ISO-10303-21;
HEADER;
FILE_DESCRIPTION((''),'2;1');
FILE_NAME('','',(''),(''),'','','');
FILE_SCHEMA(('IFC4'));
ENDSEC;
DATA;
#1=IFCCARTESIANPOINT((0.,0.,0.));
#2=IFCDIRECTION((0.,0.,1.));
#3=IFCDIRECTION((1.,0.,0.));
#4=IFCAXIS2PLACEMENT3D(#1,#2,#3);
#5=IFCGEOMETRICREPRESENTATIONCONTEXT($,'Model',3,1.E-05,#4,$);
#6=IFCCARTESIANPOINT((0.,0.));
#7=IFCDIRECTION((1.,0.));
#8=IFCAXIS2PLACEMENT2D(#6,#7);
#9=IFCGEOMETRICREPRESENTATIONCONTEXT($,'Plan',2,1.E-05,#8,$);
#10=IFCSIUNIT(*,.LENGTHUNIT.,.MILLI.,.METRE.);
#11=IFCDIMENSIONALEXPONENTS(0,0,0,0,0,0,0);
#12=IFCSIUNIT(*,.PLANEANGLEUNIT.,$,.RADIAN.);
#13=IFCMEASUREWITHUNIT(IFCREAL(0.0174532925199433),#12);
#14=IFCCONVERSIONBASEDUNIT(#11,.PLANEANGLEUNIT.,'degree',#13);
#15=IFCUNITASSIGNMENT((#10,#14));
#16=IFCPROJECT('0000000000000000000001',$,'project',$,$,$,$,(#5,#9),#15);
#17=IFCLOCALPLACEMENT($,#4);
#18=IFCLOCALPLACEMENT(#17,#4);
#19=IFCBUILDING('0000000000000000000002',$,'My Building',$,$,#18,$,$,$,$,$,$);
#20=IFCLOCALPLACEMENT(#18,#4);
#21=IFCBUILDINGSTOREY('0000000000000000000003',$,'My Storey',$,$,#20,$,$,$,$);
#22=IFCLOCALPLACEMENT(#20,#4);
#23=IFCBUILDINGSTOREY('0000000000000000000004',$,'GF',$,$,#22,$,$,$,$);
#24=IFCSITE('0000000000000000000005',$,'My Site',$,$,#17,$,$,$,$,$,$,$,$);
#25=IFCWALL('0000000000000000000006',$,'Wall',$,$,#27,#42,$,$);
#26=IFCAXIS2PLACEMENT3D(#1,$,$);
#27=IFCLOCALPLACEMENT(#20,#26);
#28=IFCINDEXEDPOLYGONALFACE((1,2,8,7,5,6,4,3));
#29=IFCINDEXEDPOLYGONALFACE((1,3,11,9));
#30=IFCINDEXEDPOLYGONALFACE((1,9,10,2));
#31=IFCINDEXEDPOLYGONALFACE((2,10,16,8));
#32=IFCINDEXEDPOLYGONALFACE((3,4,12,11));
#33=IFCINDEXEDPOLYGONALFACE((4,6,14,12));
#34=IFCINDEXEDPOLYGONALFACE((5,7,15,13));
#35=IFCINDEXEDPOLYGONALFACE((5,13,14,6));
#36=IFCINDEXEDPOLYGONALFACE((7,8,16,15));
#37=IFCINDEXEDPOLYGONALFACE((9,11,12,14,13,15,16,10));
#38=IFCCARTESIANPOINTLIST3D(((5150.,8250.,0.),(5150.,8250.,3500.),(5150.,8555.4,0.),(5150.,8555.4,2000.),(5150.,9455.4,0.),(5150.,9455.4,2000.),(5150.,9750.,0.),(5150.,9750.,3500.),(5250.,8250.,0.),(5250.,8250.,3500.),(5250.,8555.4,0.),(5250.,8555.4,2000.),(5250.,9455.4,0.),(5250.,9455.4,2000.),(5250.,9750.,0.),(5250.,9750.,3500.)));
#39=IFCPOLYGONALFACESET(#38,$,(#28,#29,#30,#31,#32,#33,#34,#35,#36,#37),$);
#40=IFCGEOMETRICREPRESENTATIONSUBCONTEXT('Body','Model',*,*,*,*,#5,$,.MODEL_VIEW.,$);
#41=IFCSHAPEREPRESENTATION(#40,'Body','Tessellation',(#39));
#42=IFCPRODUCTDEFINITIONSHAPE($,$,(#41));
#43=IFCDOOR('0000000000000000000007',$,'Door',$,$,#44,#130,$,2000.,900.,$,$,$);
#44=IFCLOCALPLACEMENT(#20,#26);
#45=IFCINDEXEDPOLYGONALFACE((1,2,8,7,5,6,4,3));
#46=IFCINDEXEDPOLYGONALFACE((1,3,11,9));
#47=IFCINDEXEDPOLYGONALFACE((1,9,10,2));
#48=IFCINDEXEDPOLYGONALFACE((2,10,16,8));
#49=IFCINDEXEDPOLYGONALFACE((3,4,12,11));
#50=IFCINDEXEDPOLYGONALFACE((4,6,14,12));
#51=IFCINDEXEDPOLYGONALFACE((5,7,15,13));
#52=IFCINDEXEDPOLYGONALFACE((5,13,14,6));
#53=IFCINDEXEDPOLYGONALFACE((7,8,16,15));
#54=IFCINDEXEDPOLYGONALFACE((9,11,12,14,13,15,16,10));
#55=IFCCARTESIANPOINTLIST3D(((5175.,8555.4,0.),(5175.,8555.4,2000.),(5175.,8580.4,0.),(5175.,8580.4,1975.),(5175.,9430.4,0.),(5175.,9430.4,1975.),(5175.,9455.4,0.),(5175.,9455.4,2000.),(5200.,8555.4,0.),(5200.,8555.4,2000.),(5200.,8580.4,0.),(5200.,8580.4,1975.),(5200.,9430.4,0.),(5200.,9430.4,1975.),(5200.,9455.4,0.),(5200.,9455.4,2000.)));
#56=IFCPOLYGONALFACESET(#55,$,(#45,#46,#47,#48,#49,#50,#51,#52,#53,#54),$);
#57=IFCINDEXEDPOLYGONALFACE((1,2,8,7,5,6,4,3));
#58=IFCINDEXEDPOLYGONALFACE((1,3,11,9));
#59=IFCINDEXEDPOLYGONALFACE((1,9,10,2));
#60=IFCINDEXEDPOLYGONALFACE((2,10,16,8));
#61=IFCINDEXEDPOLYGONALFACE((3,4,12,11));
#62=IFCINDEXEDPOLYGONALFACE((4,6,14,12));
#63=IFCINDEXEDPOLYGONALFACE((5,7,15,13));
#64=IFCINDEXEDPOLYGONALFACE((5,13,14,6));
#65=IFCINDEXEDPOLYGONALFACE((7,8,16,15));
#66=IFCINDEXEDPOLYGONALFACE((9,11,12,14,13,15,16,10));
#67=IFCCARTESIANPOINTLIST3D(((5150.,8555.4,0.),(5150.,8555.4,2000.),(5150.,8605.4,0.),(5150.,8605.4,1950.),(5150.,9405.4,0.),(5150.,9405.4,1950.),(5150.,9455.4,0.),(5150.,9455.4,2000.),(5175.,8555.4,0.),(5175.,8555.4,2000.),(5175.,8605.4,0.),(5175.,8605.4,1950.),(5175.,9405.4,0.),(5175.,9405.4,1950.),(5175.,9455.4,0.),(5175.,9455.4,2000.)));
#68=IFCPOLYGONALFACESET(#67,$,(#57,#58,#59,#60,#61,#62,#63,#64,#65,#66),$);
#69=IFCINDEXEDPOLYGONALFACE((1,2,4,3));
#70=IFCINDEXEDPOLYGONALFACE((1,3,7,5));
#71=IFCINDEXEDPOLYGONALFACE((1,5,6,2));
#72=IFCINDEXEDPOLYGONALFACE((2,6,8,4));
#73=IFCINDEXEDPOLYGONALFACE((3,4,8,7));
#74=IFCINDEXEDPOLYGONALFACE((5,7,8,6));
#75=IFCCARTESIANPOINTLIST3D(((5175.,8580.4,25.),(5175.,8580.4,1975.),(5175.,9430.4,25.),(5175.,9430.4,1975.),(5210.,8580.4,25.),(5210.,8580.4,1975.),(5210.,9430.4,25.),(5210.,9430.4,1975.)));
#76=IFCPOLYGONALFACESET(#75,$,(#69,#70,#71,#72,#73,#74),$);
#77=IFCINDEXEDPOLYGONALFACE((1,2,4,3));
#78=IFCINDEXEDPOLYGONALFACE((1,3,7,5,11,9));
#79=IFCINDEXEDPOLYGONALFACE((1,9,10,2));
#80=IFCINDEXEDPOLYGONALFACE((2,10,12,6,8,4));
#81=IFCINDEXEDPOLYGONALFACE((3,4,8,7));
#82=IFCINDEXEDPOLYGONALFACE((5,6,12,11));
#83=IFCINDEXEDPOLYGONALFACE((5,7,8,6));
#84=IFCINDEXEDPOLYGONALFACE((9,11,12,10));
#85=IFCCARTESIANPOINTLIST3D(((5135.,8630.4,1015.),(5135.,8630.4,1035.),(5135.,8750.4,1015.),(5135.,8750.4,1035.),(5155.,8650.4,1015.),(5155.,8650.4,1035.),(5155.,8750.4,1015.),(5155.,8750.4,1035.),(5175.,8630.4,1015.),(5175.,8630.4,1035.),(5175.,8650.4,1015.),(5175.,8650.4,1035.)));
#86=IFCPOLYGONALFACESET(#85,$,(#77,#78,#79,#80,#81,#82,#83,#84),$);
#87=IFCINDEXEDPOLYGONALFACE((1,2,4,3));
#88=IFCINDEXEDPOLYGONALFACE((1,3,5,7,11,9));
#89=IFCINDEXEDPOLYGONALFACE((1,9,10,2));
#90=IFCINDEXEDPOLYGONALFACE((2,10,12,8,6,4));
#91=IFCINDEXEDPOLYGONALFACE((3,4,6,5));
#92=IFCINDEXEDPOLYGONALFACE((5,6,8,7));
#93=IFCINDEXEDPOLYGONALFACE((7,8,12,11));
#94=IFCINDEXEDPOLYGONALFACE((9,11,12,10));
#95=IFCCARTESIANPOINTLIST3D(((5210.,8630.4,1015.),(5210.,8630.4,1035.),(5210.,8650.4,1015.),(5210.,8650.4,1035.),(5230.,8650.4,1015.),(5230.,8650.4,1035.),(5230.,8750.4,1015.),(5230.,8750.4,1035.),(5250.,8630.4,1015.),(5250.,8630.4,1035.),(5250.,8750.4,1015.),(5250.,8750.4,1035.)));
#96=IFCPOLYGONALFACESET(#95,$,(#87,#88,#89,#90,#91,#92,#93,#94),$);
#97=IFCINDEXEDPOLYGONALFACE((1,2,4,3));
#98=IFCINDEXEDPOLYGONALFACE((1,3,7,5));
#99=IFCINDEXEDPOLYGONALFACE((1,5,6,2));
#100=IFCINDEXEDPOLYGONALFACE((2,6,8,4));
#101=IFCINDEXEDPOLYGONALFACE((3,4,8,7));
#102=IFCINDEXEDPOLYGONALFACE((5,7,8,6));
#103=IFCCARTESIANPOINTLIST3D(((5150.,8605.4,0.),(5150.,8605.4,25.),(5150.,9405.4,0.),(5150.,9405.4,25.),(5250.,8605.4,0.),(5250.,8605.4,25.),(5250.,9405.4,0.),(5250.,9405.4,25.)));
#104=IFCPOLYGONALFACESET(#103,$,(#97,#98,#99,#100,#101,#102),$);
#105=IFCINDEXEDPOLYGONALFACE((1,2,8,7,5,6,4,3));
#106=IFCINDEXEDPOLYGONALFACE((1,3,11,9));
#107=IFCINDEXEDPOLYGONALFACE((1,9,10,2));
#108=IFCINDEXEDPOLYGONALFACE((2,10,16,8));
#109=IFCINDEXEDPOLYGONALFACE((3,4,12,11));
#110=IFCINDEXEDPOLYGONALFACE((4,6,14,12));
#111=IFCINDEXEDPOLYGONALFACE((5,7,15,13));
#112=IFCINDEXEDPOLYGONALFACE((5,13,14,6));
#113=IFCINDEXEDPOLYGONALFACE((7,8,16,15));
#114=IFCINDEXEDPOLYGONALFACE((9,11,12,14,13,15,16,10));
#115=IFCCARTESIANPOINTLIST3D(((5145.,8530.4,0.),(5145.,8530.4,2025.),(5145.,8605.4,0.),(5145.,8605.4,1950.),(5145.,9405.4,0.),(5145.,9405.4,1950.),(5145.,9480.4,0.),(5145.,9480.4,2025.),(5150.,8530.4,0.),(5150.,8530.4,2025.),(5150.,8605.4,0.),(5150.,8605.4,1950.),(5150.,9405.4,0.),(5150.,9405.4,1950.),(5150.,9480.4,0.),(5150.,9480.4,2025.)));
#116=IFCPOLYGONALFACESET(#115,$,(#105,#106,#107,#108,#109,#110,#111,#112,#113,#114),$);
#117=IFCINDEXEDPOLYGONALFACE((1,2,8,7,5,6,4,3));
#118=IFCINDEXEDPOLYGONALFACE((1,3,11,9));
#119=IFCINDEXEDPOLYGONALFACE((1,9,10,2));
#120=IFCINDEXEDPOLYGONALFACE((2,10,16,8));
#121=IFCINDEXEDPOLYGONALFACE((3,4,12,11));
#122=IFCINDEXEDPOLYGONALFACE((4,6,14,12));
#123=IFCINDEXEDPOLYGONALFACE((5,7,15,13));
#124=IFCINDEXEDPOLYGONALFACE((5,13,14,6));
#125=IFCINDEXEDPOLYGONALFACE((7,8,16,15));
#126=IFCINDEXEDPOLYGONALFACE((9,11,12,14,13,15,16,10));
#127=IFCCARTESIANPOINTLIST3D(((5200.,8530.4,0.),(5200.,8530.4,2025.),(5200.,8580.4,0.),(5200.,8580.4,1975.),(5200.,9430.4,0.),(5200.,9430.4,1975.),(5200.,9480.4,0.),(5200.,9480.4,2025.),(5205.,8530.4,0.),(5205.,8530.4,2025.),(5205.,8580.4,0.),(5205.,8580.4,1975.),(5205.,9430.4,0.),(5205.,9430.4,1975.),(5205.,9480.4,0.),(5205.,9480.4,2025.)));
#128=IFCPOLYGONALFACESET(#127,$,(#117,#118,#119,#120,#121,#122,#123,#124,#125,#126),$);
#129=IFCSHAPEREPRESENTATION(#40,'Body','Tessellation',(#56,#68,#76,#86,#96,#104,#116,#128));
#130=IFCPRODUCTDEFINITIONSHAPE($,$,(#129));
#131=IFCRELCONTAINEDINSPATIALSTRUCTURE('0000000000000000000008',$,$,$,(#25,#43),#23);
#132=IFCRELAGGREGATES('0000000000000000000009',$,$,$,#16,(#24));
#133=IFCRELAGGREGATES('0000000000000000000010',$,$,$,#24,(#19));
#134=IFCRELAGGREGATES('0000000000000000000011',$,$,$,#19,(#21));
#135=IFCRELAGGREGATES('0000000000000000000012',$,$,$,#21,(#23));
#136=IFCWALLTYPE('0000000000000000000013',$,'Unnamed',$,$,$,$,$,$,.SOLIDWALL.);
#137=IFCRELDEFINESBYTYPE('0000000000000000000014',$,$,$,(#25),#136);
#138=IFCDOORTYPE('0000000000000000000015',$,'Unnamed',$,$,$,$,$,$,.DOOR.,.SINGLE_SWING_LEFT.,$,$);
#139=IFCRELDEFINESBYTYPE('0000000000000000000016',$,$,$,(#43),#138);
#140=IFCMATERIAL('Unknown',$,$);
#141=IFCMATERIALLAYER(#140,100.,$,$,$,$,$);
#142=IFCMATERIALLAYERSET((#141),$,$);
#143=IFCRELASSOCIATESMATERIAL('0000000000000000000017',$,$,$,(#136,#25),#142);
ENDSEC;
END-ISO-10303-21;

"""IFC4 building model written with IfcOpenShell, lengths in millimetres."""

from ifc_helpers import new_model, entity, si_unit, converted_unit, frame, origin_with_axes, origin_2d_with_axis, place, context, subcontext, project, spatial, line, indexed_curve, outline, extrude, shape, source, transform, mapped, material, layer, layer_set, layer_usage, type_object, type_shapes, element, fill, save


model = new_model("IFC4")

# Units and contexts
model_context = context("Model", 3, precision=1e-05, world=origin_with_axes())
plan_context = context("Plan", 2, precision=1e-05, world=origin_2d_with_axis())
body_context_1 = subcontext(model_context, "Body", "Model", "MODEL_VIEW")
body_context_2 = subcontext(plan_context, "Body", "Plan", "PLAN_VIEW")
ifc_project = project(units=[si_unit("LENGTHUNIT", "METRE", prefix="MILLI"), converted_unit("PLANEANGLEUNIT", "degree", entity("IfcReal", 0.0174532925199433), si_unit("PLANEANGLEUNIT", "RADIAN"), dimensions=[0, 0, 0, 0, 0, 0, 0])], contexts=[model_context, plan_context])

# Site, building, storeys
site_placement = place(None, origin_with_axes())
site = spatial("IfcSite", under=ifc_project, at=site_placement, Name="My Site")
building_placement = place(site_placement, origin_with_axes())
building = spatial("IfcBuilding", under=site, at=building_placement, Name="My Building")
storey_1_placement = place(building_placement, origin_with_axes())
storey_1 = spatial("IfcBuildingStorey", under=building, at=storey_1_placement, Name="My Storey")
storey_2_placement = place(storey_1_placement, origin_with_axes())
storey_2 = spatial("IfcBuildingStorey", under=storey_1, at=storey_2_placement, Name="GF")

# Shared definitions
ifc_material = material(Name="Unknown")
ifc_layer_1 = layer(ifc_material, 100.0)
ifc_layer_set_1 = layer_set([ifc_layer_1])
wall_type_1 = type_object("IfcWallType", Name="Unnamed", PredefinedType="SOLIDWALL", material=ifc_layer_set_1)

# Shared definitions
shared_shape_1 = source(origin_with_axes(), body_context_1, "Body", "SweptSolid", [
    extrude(outline(indexed_curve([(0.0, 0.0), (900.0, 0.0), (900.0, 2000.0), (0.0, 2000.0)], segments=[line(1, 2, 3, 4, 1)])), frame((0.0, -600.0, 0.0), z_axis=(0.0, -1.0, 0.0), x_axis=(1.0, 0.0, 0.0)), (0.0, 0.0, -1.0), 1200.0),
])
door_type = type_object("IfcDoorType", Name="Unnamed", OperationType="SINGLE_SWING_LEFT", PredefinedType="DOOR")
shared_shape_2 = source(origin_with_axes(), body_context_1, "Body", "SweptSolid", [
    extrude(outline(indexed_curve([(0.0, 0.0), (0.0, 2000.0), (900.0, 2000.0), (900.0, 0.0), (875.0, 0.0), (875.0, 1975.0), (25.0, 1975.0), (25.0, 0.0)], segments=[line(1, 2, 3, 4, 5, 6, 7, 8, 1)])), frame((0.0, 25.0, 0.0), z_axis=(0.0, -1.0, 0.0), x_axis=(1.0, 0.0, 0.0)), (0.0, 0.0, -1.0), 25.0),
    extrude(outline(indexed_curve([(0.0, 0.0), (0.0, 2000.0), (900.0, 2000.0), (900.0, 0.0), (850.0, 0.0), (850.0, 1950.0), (50.0, 1950.0), (50.0, 0.0)], segments=[line(1, 2, 3, 4, 5, 6, 7, 8, 1)])), frame((0.0, 0.0, 0.0), z_axis=(0.0, -1.0, 0.0), x_axis=(1.0, 0.0, 0.0)), (0.0, 0.0, -1.0), 25.0),
    extrude(outline(indexed_curve([(0.0, 0.0), (850.0, 0.0), (850.0, 35.0), (0.0, 35.0)], segments=[line(1, 2, 3, 4, 1)])), frame((25.0, 25.0, 25.0), z_axis=(0.0, 0.0, 1.0), x_axis=(1.0, 0.0, 0.0)), (0.0, 0.0, 1.0), 1950.0),
    extrude(outline(indexed_curve([(0.0, 0.0), (0.0, -40.0), (-120.0, -40.0), (-120.0, -20.0), (-20.0, -20.0), (-20.0, 0.0)], segments=[line(1, 2, 3, 4, 5, 6, 1)])), frame((825.0, 25.0, 1015.0), z_axis=(0.0, 0.0, 1.0), x_axis=(1.0, 0.0, 0.0)), (0.0, 0.0, 1.0), 20.0),
    extrude(outline(indexed_curve([(0.0, 0.0), (0.0, 40.0), (-120.0, 40.0), (-120.0, 20.0), (-20.0, 20.0), (-20.0, 0.0)], segments=[line(1, 2, 3, 4, 5, 6, 1)])), frame((825.0, 60.0, 1015.0), z_axis=(0.0, 0.0, 1.0), x_axis=(1.0, 0.0, 0.0)), (0.0, 0.0, 1.0), 20.0),
    extrude(outline(indexed_curve([(0.0, 0.0), (800.0, 0.0), (800.0, 100.0), (0.0, 100.0)], segments=[line(1, 2, 3, 4, 1)])), frame((50.0, 0.0, 0.0), z_axis=(0.0, 0.0, 1.0), x_axis=(1.0, 0.0, 0.0)), (0.0, 0.0, 1.0), 25.0),
    extrude(outline(indexed_curve([(0.0, 0.0), (0.0, 2025.0), (950.0, 2025.0), (950.0, 0.0), (875.0, 0.0), (875.0, 1950.0), (75.0, 1950.0), (75.0, 0.0)], segments=[line(1, 2, 3, 4, 5, 6, 7, 8, 1)])), frame((-25.0, -5.0, 0.0), z_axis=(0.0, -1.0, 0.0), x_axis=(1.0, 0.0, 0.0)), (0.0, 0.0, -1.0), 5.0),
    extrude(outline(indexed_curve([(0.0, 0.0), (0.0, 2025.0), (950.0, 2025.0), (950.0, 0.0), (900.0, 0.0), (900.0, 1975.0), (50.0, 1975.0), (50.0, 0.0)], segments=[line(1, 2, 3, 4, 5, 6, 7, 8, 1)])), frame((-25.0, 50.0, 0.0), z_axis=(0.0, -1.0, 0.0), x_axis=(1.0, 0.0, 0.0)), (0.0, 0.0, -1.0), 5.0),
])
shared_shape_3 = source(origin_with_axes(), body_context_2, "Body", "Curve2D", [
    entity("IfcIndexedPolyCurve", entity("IfcCartesianPointList2D", [[0.0, 0.0], [0.0, 50.0], [25.0, 50.0], [25.0, 25.0], [50.0, 25.0], [50.0, 0.0]]), [entity("IfcLineIndex", [1, 2, 3, 4, 5, 6, 1])]),
    entity("IfcIndexedPolyCurve", entity("IfcCartesianPointList2D", [[900.0, 0.0], [900.0, 50.0], [875.0, 50.0], [875.0, 25.0], [850.0, 25.0], [850.0, 0.0]]), [entity("IfcLineIndex", [1, 2, 3, 4, 5, 6, 1])]),
    entity("IfcTrimmedCurve", entity("IfcEllipse", entity("IfcAxis2Placement2D", entity("IfcCartesianPoint", [60.0, 50.0]), entity("IfcDirection", [1.0, 0.0])), 815.0, 850.0), [entity("IfcCartesianPoint", [875.0, 50.0])], [entity("IfcCartesianPoint", [60.0, 900.0])], True, "CARTESIAN"),
    entity("IfcIndexedPolyCurve", entity("IfcCartesianPointList2D", [[25.0, 50.0], [60.0, 50.0], [60.0, 900.0], [25.0, 900.0]]), [entity("IfcLineIndex", [1, 2, 3, 4, 1])]),
])
type_shapes(door_type, [shared_shape_2, shared_shape_3])

# Wall, opening, door
ifc_layer_usage_1 = layer_usage(ifc_layer_set_1, "AXIS2", "POSITIVE", 0.0)
wall_1_placement = place(storey_2_placement, frame((5150.0, 9750.0, 0.0), z_axis=(0.0, 0.0, 1.0), x_axis=(0.0, -1.0, 0.0)))
wall_1 = element("IfcWall", 1, at=wall_1_placement, inside=storey_2, type_object=wall_type_1, material=ifc_layer_usage_1, Name="Wall", context=body_context_1, shape_type="SweptSolid", body=[
    extrude(outline(indexed_curve([(0.0, 0.0), (0.0, 100.0), (1500.0, 100.0), (1500.0, 0.0)], segments=[line(1, 2, 3, 4, 1)])), origin_with_axes(), (0.0, 0.0, 1.0), 3500.0),
])
opening_1_placement = place(wall_1_placement, frame((294.6, 0.0, 0.0), z_axis=(0.0, 0.0, 1.0), x_axis=(1.0, 0.0, 0.0)))
opening_1 = element("IfcOpeningElement", 2, at=opening_1_placement, cuts=wall_1, PredefinedType="OPENING", context=body_context_1, shape_type="MappedRepresentation", body=[
    mapped(shared_shape_1, transform((0.0, 0.0, 0.0), x_axis=(1.0, 0.0, 0.0), y_axis=(0.0, 1.0, 0.0), z_axis=(0.0, 0.0, 1.0), scale=1.0)),
])
door_1_placement = place(opening_1_placement, origin_with_axes())
door_1 = element("IfcDoor", 3, at=door_1_placement, inside=storey_2, type_object=door_type, Name="Door", OverallHeight=2000.0, OverallWidth=900.0, shapes=[
    shape(body_context_1, "Body", "MappedRepresentation", [mapped(shared_shape_2, transform((0.0, 0.0, 0.0), x_axis=(1.0, 0.0, 0.0), y_axis=(0.0, 1.0, 0.0), z_axis=(0.0, 0.0, 1.0), scale=1.0))]),
    shape(body_context_2, "Body", "MappedRepresentation", [mapped(shared_shape_3, transform((0.0, 0.0, 0.0), x_axis=(1.0, 0.0, 0.0), y_axis=(0.0, 1.0, 0.0), z_axis=(0.0, 0.0, 1.0), scale=1.0))]),
])
fill(opening_1, door_1)

save(model, "model.ifc")
